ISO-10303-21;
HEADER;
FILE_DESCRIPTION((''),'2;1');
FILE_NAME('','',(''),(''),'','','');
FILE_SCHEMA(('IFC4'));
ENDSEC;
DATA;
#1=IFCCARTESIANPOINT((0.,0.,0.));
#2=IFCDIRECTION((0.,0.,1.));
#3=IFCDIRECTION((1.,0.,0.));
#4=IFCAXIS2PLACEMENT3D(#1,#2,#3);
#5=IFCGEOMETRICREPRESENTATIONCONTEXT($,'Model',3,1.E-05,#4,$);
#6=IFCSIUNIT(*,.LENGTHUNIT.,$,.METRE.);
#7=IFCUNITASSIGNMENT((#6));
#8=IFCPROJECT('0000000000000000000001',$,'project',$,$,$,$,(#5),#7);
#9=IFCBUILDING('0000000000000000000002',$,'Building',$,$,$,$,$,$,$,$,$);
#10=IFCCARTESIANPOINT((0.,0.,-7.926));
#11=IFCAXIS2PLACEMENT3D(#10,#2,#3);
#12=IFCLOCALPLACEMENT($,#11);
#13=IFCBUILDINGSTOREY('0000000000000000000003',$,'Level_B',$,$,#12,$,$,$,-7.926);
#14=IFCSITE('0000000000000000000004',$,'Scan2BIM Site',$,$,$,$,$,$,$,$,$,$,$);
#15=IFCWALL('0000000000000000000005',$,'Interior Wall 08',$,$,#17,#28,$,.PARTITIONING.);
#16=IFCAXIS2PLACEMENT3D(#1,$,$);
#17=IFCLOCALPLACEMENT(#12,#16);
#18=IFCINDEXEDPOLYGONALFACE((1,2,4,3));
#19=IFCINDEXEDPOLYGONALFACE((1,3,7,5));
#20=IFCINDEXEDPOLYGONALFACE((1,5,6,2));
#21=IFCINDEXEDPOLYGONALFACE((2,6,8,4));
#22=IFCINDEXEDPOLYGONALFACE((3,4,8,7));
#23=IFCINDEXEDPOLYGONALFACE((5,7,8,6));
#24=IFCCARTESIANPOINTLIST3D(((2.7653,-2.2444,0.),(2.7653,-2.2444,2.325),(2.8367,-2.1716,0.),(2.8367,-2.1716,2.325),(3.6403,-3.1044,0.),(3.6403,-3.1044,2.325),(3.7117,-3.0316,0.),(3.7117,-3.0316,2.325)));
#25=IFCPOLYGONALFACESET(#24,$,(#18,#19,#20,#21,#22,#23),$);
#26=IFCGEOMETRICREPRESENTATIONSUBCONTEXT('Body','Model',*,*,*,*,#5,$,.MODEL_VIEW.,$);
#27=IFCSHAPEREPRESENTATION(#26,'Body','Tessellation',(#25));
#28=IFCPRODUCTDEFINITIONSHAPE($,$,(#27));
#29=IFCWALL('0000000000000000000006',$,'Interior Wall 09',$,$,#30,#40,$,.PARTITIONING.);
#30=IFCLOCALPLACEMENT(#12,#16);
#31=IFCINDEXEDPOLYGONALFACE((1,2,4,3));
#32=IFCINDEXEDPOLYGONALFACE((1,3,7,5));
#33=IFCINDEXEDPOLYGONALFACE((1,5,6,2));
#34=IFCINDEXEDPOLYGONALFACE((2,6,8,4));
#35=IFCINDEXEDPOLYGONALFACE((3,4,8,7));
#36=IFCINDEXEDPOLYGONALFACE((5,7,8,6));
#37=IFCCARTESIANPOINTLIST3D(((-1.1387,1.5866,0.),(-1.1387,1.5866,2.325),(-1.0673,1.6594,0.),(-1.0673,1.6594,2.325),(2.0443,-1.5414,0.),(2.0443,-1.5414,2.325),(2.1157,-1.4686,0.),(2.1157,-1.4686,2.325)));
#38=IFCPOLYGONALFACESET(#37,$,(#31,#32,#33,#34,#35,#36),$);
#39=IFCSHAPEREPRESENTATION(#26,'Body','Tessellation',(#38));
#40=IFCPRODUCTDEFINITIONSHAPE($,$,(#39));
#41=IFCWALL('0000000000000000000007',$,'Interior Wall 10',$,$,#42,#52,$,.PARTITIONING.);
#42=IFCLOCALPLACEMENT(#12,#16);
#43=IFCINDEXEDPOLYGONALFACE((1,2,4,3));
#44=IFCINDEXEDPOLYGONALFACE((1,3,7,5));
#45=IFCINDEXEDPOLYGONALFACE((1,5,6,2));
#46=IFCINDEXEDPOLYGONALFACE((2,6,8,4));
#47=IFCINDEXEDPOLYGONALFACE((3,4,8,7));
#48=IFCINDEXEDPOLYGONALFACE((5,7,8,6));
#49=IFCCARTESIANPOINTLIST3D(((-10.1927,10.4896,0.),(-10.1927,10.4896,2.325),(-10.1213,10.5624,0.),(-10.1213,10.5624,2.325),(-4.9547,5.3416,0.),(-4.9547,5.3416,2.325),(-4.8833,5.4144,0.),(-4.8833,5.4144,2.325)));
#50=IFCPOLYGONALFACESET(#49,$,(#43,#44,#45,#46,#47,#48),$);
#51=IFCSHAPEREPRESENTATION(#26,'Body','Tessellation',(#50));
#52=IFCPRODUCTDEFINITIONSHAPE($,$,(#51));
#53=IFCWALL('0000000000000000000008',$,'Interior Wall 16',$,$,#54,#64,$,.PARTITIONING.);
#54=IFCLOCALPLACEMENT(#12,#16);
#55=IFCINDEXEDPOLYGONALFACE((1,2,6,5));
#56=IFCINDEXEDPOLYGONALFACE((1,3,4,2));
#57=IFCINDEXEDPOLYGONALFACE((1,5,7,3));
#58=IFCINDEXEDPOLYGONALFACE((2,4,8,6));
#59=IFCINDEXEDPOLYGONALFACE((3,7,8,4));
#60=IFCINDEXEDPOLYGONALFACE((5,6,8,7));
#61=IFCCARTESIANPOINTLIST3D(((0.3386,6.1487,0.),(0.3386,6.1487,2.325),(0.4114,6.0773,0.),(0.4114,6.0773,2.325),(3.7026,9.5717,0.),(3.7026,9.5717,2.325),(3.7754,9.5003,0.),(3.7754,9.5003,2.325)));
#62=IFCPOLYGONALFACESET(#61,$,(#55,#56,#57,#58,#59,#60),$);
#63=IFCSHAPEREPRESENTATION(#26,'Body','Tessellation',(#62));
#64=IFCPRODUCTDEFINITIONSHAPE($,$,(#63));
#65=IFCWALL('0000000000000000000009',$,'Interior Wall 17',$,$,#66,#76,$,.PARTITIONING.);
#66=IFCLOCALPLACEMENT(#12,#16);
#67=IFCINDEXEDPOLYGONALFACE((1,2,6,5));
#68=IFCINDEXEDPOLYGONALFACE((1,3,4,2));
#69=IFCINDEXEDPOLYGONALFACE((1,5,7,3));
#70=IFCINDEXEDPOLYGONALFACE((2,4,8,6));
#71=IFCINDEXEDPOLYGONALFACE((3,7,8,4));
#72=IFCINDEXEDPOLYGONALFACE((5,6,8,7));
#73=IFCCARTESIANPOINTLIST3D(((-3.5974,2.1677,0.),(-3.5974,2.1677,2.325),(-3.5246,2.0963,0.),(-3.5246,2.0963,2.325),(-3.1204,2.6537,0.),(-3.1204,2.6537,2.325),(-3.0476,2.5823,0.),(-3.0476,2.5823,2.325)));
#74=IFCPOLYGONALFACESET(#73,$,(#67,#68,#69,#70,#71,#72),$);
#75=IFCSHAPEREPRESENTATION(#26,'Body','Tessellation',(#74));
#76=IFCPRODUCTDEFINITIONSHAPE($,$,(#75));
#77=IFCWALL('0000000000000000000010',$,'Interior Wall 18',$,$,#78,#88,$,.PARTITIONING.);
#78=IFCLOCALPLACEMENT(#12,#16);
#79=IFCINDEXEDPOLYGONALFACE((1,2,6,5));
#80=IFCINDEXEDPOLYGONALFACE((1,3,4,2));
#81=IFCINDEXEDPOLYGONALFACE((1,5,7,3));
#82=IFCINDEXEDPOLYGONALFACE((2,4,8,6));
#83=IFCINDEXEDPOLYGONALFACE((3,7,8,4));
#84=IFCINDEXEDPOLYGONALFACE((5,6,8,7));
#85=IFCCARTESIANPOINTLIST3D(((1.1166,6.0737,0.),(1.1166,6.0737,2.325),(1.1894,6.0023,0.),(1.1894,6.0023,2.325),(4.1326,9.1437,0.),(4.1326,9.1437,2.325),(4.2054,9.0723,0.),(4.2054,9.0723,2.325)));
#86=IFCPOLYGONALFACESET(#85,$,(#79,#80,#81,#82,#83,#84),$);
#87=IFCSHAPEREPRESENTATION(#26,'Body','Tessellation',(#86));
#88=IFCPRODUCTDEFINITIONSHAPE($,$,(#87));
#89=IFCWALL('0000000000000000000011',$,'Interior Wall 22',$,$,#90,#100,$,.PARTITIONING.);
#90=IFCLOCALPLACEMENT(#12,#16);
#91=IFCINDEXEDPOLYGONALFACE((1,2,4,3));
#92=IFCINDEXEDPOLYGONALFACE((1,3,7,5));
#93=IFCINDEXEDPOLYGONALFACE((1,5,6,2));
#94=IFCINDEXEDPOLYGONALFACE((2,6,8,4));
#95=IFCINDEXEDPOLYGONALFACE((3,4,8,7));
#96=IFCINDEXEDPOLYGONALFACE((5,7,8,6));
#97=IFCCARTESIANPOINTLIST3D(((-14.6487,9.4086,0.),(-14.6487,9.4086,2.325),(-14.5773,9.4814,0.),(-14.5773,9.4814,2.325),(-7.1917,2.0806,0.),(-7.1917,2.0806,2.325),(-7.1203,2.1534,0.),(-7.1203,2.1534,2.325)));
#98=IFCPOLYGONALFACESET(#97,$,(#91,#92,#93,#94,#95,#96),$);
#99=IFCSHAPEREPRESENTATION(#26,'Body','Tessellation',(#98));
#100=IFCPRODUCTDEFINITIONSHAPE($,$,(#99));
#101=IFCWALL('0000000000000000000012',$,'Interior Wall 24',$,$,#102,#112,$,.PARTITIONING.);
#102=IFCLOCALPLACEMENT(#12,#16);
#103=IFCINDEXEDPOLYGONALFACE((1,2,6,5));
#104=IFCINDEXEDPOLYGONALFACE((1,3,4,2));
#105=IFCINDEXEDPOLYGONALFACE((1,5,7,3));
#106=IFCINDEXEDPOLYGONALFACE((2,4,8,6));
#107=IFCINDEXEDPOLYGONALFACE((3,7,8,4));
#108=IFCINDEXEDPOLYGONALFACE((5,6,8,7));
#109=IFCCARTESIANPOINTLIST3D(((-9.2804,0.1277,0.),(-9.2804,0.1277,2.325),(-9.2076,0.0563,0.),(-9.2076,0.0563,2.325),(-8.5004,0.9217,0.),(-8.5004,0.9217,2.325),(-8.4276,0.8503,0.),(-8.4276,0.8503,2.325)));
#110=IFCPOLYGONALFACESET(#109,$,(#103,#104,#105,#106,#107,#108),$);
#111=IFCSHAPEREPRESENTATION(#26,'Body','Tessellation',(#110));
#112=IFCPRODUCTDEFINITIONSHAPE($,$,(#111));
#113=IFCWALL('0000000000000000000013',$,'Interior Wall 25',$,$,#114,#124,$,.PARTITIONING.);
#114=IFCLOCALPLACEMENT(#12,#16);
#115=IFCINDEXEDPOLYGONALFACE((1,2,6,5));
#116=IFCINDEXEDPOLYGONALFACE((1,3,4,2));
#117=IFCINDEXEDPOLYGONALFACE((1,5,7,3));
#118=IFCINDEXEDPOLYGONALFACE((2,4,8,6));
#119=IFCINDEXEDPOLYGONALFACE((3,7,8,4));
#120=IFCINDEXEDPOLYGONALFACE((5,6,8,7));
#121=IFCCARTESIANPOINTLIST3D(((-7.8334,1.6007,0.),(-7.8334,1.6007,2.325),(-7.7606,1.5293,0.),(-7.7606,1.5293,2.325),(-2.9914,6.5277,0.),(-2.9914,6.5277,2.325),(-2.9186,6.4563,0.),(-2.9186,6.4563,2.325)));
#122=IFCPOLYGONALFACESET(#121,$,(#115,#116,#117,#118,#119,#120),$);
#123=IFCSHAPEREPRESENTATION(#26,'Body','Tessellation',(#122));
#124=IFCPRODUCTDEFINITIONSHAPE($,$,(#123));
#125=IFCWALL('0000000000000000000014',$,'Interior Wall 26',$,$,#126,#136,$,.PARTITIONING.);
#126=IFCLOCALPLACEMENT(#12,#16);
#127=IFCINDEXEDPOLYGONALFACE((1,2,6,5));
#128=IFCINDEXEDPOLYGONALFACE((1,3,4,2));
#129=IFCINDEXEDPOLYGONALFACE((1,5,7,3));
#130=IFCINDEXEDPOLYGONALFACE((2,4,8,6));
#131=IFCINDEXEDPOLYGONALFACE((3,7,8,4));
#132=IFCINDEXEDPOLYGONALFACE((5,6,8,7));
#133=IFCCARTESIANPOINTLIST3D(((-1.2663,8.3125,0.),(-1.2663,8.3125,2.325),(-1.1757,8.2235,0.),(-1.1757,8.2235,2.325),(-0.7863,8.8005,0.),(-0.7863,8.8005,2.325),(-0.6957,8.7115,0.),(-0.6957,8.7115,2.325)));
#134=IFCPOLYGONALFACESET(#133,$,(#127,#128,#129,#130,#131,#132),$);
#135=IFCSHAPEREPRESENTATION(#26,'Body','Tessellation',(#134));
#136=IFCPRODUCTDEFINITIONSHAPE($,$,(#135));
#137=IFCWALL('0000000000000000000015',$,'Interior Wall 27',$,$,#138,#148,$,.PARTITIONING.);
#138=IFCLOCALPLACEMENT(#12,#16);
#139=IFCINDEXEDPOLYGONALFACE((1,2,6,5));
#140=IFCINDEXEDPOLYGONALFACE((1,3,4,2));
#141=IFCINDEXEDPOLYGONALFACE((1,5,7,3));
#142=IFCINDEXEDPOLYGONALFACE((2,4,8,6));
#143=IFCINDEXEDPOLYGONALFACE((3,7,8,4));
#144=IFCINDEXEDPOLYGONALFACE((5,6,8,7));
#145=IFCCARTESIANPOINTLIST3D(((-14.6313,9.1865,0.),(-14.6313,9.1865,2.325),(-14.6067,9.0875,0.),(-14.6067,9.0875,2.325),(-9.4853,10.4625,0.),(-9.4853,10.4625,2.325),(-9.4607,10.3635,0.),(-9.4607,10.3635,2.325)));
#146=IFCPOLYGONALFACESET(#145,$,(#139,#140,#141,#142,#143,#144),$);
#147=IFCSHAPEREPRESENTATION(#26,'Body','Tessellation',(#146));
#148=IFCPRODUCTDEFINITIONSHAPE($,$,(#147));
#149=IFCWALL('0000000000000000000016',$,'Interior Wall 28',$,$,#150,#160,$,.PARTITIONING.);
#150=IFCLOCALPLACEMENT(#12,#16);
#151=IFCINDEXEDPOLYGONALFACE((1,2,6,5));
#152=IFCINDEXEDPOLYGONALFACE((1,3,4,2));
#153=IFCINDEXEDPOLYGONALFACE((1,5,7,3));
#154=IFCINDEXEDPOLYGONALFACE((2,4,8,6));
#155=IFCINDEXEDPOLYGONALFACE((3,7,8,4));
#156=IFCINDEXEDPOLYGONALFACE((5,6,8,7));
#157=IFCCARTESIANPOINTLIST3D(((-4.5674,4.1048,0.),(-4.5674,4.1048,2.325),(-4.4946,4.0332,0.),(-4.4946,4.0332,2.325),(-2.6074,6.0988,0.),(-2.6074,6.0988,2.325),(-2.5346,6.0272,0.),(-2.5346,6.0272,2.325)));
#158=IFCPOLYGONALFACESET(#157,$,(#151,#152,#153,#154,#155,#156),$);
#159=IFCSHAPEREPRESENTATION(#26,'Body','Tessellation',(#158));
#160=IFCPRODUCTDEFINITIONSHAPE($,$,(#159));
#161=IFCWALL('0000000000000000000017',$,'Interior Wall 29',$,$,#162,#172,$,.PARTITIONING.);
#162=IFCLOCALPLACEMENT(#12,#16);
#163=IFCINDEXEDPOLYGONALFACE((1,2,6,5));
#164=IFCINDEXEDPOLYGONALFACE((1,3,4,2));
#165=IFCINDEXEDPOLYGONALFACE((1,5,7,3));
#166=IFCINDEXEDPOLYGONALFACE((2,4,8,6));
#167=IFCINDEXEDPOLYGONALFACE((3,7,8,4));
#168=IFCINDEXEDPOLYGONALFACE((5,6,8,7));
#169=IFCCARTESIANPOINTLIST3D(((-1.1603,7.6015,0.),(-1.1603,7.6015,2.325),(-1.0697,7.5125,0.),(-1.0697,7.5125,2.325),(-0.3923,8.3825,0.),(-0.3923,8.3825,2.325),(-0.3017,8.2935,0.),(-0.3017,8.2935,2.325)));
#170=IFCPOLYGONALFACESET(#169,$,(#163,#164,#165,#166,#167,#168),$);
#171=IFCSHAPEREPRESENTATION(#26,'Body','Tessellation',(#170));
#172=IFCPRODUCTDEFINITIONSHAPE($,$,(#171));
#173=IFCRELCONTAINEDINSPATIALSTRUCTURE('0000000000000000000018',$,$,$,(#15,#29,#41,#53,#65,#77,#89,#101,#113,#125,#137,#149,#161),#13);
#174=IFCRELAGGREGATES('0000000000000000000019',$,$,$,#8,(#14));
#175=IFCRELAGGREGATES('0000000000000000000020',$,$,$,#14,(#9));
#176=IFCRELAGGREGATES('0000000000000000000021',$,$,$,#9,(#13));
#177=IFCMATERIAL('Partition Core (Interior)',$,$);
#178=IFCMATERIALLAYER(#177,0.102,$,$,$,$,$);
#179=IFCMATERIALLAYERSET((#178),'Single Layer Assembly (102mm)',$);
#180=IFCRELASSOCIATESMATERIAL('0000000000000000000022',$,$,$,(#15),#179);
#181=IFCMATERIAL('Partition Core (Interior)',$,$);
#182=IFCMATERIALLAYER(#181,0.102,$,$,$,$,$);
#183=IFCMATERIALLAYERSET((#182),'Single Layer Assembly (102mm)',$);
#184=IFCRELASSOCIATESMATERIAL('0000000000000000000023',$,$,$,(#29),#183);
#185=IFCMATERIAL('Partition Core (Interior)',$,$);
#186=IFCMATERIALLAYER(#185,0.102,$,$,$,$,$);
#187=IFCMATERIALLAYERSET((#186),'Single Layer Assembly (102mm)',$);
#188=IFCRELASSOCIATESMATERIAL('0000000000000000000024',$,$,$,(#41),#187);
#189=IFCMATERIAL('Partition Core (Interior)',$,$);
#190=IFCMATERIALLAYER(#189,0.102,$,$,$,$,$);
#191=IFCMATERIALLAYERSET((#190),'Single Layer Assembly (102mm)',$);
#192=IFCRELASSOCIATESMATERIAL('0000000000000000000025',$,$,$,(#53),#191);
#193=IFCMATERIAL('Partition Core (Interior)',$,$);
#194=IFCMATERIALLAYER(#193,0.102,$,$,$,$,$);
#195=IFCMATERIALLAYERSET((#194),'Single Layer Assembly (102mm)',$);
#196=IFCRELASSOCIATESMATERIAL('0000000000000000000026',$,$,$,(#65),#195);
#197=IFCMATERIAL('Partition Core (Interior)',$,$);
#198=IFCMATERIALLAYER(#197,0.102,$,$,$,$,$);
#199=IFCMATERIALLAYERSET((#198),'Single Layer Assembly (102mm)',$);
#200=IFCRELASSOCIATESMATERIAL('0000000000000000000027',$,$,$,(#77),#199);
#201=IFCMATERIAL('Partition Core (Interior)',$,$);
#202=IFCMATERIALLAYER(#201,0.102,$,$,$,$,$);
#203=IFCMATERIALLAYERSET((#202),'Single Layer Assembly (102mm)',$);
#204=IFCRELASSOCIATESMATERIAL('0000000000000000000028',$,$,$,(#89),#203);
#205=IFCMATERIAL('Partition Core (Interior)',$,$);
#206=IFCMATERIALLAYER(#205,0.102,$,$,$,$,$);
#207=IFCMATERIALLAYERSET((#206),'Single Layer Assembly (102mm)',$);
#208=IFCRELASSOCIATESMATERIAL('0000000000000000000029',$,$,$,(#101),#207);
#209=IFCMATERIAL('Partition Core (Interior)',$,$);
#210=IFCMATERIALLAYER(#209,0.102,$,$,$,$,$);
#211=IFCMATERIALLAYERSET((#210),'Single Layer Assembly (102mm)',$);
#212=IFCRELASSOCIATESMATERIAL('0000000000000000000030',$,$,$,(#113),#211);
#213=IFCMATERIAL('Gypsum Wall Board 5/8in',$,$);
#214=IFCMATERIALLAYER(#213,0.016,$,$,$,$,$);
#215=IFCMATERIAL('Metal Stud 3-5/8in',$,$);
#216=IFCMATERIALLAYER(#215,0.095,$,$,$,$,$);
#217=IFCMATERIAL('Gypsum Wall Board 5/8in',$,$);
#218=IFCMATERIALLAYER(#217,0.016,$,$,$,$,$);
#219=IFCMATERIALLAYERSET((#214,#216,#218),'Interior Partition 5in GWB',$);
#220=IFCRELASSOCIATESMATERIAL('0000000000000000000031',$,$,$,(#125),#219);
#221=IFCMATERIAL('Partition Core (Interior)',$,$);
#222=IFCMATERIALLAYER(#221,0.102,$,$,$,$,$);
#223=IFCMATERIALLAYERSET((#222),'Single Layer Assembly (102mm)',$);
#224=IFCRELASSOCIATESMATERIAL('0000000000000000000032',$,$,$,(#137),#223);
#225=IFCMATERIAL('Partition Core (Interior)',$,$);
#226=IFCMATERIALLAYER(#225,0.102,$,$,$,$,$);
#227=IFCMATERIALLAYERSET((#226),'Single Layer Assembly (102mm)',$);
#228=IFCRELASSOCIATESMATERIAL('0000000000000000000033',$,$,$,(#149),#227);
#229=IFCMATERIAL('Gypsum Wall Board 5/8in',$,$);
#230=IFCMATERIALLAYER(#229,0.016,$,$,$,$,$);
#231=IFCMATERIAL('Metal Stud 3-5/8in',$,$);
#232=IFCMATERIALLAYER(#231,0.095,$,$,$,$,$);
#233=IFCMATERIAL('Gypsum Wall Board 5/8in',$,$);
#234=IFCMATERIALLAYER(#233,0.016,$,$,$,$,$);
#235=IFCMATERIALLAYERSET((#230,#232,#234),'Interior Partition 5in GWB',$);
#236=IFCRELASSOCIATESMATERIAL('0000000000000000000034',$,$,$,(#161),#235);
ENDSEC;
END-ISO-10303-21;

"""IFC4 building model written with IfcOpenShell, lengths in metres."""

from ifc_helpers import new_model, si_unit, frame, origin, origin_with_axes, place, context, subcontext, project, spatial, rectangle, extrude, material, layer, layer_set, element, save


model = new_model("IFC4")

# Units and contexts
model_context = context("Model", 3, precision=1e-05, world=origin_with_axes())
body_context = subcontext(model_context, "Body", "Model", "MODEL_VIEW")
ifc_project = project(units=[si_unit("LENGTHUNIT", "METRE")], contexts=[model_context])

# Site, building, storey
site = spatial("IfcSite", under=ifc_project, Name="Scan2BIM Site")
building = spatial("IfcBuilding", under=site, Name="Building")
storey_placement = place(None, frame((0.0, 0.0, -7.926), z_axis=(0.0, 0.0, 1.0), x_axis=(1.0, 0.0, 0.0)))
storey = spatial("IfcBuildingStorey", under=building, at=storey_placement, Name="Level_B", Elevation=-7.926)

# Walls
ifc_material_1 = material(Name="Partition Core (Interior)")
ifc_layer_1 = layer(ifc_material_1, 0.102)
ifc_layer_set_1 = layer_set([ifc_layer_1], Name="Single Layer Assembly (102mm)")
wall_1_placement = place(storey_placement, frame((3.2385, -2.638, 0.0), z_axis=(0.0, 0.0, 1.0), x_axis=(-0.713193, 0.700967, 0.0)))
element("IfcWall", 1, at=wall_1_placement, inside=storey, material=ifc_layer_set_1, Name="Interior Wall 08", PredefinedType="PARTITIONING", context=body_context, shape_type="SweptSolid", body=[
    extrude(rectangle(XDim=1.2269, YDim=0.102), origin(), (0.0, 0.0, 1.0), 2.325),
])
ifc_material_2 = material(Name="Partition Core (Interior)")
ifc_layer_2 = layer(ifc_material_2, 0.102)
ifc_layer_set_2 = layer_set([ifc_layer_2], Name="Single Layer Assembly (102mm)")
wall_2_placement = place(storey_placement, frame((0.4885, 0.059, 0.0), z_axis=(0.0, 0.0, 1.0), x_axis=(-0.713242, 0.700918, 0.0)))
element("IfcWall", 2, at=wall_2_placement, inside=storey, material=ifc_layer_set_2, Name="Interior Wall 09", PredefinedType="PARTITIONING", context=body_context, shape_type="SweptSolid", body=[
    extrude(rectangle(XDim=4.4627, YDim=0.102), origin(), (0.0, 0.0, 1.0), 2.325),
])
ifc_material_3 = material(Name="Partition Core (Interior)")
ifc_layer_3 = layer(ifc_material_3, 0.102)
ifc_layer_set_3 = layer_set([ifc_layer_3], Name="Single Layer Assembly (102mm)")
wall_3_placement = place(storey_placement, frame((-7.538, 7.952, 0.0), z_axis=(0.0, 0.0, 1.0), x_axis=(-0.713207, 0.700953, 0.0)))
element("IfcWall", 3, at=wall_3_placement, inside=storey, material=ifc_layer_set_3, Name="Interior Wall 10", PredefinedType="PARTITIONING", context=body_context, shape_type="SweptSolid", body=[
    extrude(rectangle(XDim=7.3443, YDim=0.102), origin(), (0.0, 0.0, 1.0), 2.325),
])
ifc_material_4 = material(Name="Partition Core (Interior)")
ifc_layer_4 = layer(ifc_material_4, 0.102)
ifc_layer_set_4 = layer_set([ifc_layer_4], Name="Single Layer Assembly (102mm)")
wall_4_placement = place(storey_placement, frame((2.057, 7.8245, 0.0), z_axis=(0.0, 0.0, 1.0), x_axis=(-0.700933, -0.713227, 0.0)))
element("IfcWall", 4, at=wall_4_placement, inside=storey, material=ifc_layer_set_4, Name="Interior Wall 16", PredefinedType="PARTITIONING", context=body_context, shape_type="SweptSolid", body=[
    extrude(rectangle(XDim=4.7993, YDim=0.102), origin(), (0.0, 0.0, 1.0), 2.325),
])
ifc_material_5 = material(Name="Partition Core (Interior)")
ifc_layer_5 = layer(ifc_material_5, 0.102)
ifc_layer_set_5 = layer_set([ifc_layer_5], Name="Single Layer Assembly (102mm)")
wall_5_placement = place(storey_placement, frame((-3.3225, 2.375, 0.0), z_axis=(0.0, 0.0, 1.0), x_axis=(-0.700468, -0.713684, 0.0)))
element("IfcWall", 5, at=wall_5_placement, inside=storey, material=ifc_layer_set_5, Name="Interior Wall 17", PredefinedType="PARTITIONING", context=body_context, shape_type="SweptSolid", body=[
    extrude(rectangle(XDim=0.681, YDim=0.102), origin(), (0.0, 0.0, 1.0), 2.325),
])
ifc_material_6 = material(Name="Partition Core (Interior)")
ifc_layer_6 = layer(ifc_material_6, 0.102)
ifc_layer_set_6 = layer_set([ifc_layer_6], Name="Single Layer Assembly (102mm)")
wall_6_placement = place(storey_placement, frame((2.661, 7.573, 0.0), z_axis=(0.0, 0.0, 1.0), x_axis=(0.700805, 0.713353, 0.0)))
element("IfcWall", 6, at=wall_6_placement, inside=storey, material=ifc_layer_set_6, Name="Interior Wall 18", PredefinedType="PARTITIONING", context=body_context, shape_type="SweptSolid", body=[
    extrude(rectangle(XDim=4.3036, YDim=0.102), origin(), (0.0, 0.0, 1.0), 2.325),
])
ifc_material_7 = material(Name="Partition Core (Interior)")
ifc_layer_7 = layer(ifc_material_7, 0.102)
ifc_layer_set_7 = layer_set([ifc_layer_7], Name="Single Layer Assembly (102mm)")
wall_7_placement = place(storey_placement, frame((-10.8845, 5.781, 0.0), z_axis=(0.0, 0.0, 1.0), x_axis=(0.713249, -0.700911, 0.0)))
element("IfcWall", 7, at=wall_7_placement, inside=storey, material=ifc_layer_set_7, Name="Interior Wall 22", PredefinedType="PARTITIONING", context=body_context, shape_type="SweptSolid", body=[
    extrude(rectangle(XDim=10.455, YDim=0.102), origin(), (0.0, 0.0, 1.0), 2.325),
])
ifc_material_8 = material(Name="Partition Core (Interior)")
ifc_layer_8 = layer(ifc_material_8, 0.102)
ifc_layer_set_8 = layer_set([ifc_layer_8], Name="Single Layer Assembly (102mm)")
wall_8_placement = place(storey_placement, frame((-8.854, 0.489, 0.0), z_axis=(0.0, 0.0, 1.0), x_axis=(0.70079, 0.713368, 0.0)))
element("IfcWall", 8, at=wall_8_placement, inside=storey, material=ifc_layer_set_8, Name="Interior Wall 24", PredefinedType="PARTITIONING", context=body_context, shape_type="SweptSolid", body=[
    extrude(rectangle(XDim=1.113, YDim=0.102), origin(), (0.0, 0.0, 1.0), 2.325),
])
ifc_material_9 = material(Name="Partition Core (Interior)")
ifc_layer_9 = layer(ifc_material_9, 0.102)
ifc_layer_set_9 = layer_set([ifc_layer_9], Name="Single Layer Assembly (102mm)")
wall_9_placement = place(storey_placement, frame((-5.376, 4.0285, 0.0), z_axis=(0.0, 0.0, 1.0), x_axis=(0.700928, 0.713232, 0.0)))
element("IfcWall", 9, at=wall_9_placement, inside=storey, material=ifc_layer_set_9, Name="Interior Wall 25", PredefinedType="PARTITIONING", context=body_context, shape_type="SweptSolid", body=[
    extrude(rectangle(XDim=6.908, YDim=0.102), origin(), (0.0, 0.0, 1.0), 2.325),
])
ifc_material_10 = material(Name="Gypsum Wall Board 5/8in")
ifc_layer_10 = layer(ifc_material_10, 0.016)
ifc_material_11 = material(Name="Metal Stud 3-5/8in")
ifc_layer_11 = layer(ifc_material_11, 0.095)
ifc_material_12 = material(Name="Gypsum Wall Board 5/8in")
ifc_layer_12 = layer(ifc_material_12, 0.016)
ifc_layer_set_10 = layer_set([ifc_layer_10, ifc_layer_11, ifc_layer_12], Name="Interior Partition 5in GWB")
wall_10_placement = place(storey_placement, frame((-0.981, 8.512, 0.0), z_axis=(0.0, 0.0, 1.0), x_axis=(0.701239, 0.712926, 0.0)))
element("IfcWall", 10, at=wall_10_placement, inside=storey, material=ifc_layer_set_10, Name="Interior Wall 26", PredefinedType="PARTITIONING", context=body_context, shape_type="SweptSolid", body=[
    extrude(rectangle(XDim=0.6845, YDim=0.127), origin(), (0.0, 0.0, 1.0), 2.325),
])
ifc_material_13 = material(Name="Partition Core (Interior)")
ifc_layer_13 = layer(ifc_material_13, 0.102)
ifc_layer_set_11 = layer_set([ifc_layer_13], Name="Single Layer Assembly (102mm)")
wall_11_placement = place(storey_placement, frame((-12.046, 9.775, 0.0), z_axis=(0.0, 0.0, 1.0), x_axis=(0.970607, 0.240671, 0.0)))
element("IfcWall", 11, at=wall_11_placement, inside=storey, material=ifc_layer_set_11, Name="Interior Wall 27", PredefinedType="PARTITIONING", context=body_context, shape_type="SweptSolid", body=[
    extrude(rectangle(XDim=5.3018, YDim=0.102), origin(), (0.0, 0.0, 1.0), 2.325),
])
ifc_material_14 = material(Name="Partition Core (Interior)")
ifc_layer_14 = layer(ifc_material_14, 0.102)
ifc_layer_set_12 = layer_set([ifc_layer_14], Name="Single Layer Assembly (102mm)")
wall_12_placement = place(storey_placement, frame((-3.551, 5.066, 0.0), z_axis=(0.0, 0.0, 1.0), x_axis=(0.701001, 0.713161, 0.0)))
element("IfcWall", 12, at=wall_12_placement, inside=storey, material=ifc_layer_set_12, Name="Interior Wall 28", PredefinedType="PARTITIONING", context=body_context, shape_type="SweptSolid", body=[
    extrude(rectangle(XDim=2.796, YDim=0.102), origin(), (0.0, 0.0, 1.0), 2.325),
])
ifc_material_15 = material(Name="Gypsum Wall Board 5/8in")
ifc_layer_15 = layer(ifc_material_15, 0.016)
ifc_material_16 = material(Name="Metal Stud 3-5/8in")
ifc_layer_16 = layer(ifc_material_16, 0.095)
ifc_material_17 = material(Name="Gypsum Wall Board 5/8in")
ifc_layer_17 = layer(ifc_material_17, 0.016)
ifc_layer_set_13 = layer_set([ifc_layer_15, ifc_layer_16, ifc_layer_17], Name="Interior Partition 5in GWB")
wall_13_placement = place(storey_placement, frame((-0.731, 7.9475, 0.0), z_axis=(0.0, 0.0, 1.0), x_axis=(0.701148, 0.713016, 0.0)))
element("IfcWall", 13, at=wall_13_placement, inside=storey, material=ifc_layer_set_13, Name="Interior Wall 29", PredefinedType="PARTITIONING", context=body_context, shape_type="SweptSolid", body=[
    extrude(rectangle(XDim=1.0953, YDim=0.127), origin(), (0.0, 0.0, 1.0), 2.325),
])

save(model, "model.ifc")
